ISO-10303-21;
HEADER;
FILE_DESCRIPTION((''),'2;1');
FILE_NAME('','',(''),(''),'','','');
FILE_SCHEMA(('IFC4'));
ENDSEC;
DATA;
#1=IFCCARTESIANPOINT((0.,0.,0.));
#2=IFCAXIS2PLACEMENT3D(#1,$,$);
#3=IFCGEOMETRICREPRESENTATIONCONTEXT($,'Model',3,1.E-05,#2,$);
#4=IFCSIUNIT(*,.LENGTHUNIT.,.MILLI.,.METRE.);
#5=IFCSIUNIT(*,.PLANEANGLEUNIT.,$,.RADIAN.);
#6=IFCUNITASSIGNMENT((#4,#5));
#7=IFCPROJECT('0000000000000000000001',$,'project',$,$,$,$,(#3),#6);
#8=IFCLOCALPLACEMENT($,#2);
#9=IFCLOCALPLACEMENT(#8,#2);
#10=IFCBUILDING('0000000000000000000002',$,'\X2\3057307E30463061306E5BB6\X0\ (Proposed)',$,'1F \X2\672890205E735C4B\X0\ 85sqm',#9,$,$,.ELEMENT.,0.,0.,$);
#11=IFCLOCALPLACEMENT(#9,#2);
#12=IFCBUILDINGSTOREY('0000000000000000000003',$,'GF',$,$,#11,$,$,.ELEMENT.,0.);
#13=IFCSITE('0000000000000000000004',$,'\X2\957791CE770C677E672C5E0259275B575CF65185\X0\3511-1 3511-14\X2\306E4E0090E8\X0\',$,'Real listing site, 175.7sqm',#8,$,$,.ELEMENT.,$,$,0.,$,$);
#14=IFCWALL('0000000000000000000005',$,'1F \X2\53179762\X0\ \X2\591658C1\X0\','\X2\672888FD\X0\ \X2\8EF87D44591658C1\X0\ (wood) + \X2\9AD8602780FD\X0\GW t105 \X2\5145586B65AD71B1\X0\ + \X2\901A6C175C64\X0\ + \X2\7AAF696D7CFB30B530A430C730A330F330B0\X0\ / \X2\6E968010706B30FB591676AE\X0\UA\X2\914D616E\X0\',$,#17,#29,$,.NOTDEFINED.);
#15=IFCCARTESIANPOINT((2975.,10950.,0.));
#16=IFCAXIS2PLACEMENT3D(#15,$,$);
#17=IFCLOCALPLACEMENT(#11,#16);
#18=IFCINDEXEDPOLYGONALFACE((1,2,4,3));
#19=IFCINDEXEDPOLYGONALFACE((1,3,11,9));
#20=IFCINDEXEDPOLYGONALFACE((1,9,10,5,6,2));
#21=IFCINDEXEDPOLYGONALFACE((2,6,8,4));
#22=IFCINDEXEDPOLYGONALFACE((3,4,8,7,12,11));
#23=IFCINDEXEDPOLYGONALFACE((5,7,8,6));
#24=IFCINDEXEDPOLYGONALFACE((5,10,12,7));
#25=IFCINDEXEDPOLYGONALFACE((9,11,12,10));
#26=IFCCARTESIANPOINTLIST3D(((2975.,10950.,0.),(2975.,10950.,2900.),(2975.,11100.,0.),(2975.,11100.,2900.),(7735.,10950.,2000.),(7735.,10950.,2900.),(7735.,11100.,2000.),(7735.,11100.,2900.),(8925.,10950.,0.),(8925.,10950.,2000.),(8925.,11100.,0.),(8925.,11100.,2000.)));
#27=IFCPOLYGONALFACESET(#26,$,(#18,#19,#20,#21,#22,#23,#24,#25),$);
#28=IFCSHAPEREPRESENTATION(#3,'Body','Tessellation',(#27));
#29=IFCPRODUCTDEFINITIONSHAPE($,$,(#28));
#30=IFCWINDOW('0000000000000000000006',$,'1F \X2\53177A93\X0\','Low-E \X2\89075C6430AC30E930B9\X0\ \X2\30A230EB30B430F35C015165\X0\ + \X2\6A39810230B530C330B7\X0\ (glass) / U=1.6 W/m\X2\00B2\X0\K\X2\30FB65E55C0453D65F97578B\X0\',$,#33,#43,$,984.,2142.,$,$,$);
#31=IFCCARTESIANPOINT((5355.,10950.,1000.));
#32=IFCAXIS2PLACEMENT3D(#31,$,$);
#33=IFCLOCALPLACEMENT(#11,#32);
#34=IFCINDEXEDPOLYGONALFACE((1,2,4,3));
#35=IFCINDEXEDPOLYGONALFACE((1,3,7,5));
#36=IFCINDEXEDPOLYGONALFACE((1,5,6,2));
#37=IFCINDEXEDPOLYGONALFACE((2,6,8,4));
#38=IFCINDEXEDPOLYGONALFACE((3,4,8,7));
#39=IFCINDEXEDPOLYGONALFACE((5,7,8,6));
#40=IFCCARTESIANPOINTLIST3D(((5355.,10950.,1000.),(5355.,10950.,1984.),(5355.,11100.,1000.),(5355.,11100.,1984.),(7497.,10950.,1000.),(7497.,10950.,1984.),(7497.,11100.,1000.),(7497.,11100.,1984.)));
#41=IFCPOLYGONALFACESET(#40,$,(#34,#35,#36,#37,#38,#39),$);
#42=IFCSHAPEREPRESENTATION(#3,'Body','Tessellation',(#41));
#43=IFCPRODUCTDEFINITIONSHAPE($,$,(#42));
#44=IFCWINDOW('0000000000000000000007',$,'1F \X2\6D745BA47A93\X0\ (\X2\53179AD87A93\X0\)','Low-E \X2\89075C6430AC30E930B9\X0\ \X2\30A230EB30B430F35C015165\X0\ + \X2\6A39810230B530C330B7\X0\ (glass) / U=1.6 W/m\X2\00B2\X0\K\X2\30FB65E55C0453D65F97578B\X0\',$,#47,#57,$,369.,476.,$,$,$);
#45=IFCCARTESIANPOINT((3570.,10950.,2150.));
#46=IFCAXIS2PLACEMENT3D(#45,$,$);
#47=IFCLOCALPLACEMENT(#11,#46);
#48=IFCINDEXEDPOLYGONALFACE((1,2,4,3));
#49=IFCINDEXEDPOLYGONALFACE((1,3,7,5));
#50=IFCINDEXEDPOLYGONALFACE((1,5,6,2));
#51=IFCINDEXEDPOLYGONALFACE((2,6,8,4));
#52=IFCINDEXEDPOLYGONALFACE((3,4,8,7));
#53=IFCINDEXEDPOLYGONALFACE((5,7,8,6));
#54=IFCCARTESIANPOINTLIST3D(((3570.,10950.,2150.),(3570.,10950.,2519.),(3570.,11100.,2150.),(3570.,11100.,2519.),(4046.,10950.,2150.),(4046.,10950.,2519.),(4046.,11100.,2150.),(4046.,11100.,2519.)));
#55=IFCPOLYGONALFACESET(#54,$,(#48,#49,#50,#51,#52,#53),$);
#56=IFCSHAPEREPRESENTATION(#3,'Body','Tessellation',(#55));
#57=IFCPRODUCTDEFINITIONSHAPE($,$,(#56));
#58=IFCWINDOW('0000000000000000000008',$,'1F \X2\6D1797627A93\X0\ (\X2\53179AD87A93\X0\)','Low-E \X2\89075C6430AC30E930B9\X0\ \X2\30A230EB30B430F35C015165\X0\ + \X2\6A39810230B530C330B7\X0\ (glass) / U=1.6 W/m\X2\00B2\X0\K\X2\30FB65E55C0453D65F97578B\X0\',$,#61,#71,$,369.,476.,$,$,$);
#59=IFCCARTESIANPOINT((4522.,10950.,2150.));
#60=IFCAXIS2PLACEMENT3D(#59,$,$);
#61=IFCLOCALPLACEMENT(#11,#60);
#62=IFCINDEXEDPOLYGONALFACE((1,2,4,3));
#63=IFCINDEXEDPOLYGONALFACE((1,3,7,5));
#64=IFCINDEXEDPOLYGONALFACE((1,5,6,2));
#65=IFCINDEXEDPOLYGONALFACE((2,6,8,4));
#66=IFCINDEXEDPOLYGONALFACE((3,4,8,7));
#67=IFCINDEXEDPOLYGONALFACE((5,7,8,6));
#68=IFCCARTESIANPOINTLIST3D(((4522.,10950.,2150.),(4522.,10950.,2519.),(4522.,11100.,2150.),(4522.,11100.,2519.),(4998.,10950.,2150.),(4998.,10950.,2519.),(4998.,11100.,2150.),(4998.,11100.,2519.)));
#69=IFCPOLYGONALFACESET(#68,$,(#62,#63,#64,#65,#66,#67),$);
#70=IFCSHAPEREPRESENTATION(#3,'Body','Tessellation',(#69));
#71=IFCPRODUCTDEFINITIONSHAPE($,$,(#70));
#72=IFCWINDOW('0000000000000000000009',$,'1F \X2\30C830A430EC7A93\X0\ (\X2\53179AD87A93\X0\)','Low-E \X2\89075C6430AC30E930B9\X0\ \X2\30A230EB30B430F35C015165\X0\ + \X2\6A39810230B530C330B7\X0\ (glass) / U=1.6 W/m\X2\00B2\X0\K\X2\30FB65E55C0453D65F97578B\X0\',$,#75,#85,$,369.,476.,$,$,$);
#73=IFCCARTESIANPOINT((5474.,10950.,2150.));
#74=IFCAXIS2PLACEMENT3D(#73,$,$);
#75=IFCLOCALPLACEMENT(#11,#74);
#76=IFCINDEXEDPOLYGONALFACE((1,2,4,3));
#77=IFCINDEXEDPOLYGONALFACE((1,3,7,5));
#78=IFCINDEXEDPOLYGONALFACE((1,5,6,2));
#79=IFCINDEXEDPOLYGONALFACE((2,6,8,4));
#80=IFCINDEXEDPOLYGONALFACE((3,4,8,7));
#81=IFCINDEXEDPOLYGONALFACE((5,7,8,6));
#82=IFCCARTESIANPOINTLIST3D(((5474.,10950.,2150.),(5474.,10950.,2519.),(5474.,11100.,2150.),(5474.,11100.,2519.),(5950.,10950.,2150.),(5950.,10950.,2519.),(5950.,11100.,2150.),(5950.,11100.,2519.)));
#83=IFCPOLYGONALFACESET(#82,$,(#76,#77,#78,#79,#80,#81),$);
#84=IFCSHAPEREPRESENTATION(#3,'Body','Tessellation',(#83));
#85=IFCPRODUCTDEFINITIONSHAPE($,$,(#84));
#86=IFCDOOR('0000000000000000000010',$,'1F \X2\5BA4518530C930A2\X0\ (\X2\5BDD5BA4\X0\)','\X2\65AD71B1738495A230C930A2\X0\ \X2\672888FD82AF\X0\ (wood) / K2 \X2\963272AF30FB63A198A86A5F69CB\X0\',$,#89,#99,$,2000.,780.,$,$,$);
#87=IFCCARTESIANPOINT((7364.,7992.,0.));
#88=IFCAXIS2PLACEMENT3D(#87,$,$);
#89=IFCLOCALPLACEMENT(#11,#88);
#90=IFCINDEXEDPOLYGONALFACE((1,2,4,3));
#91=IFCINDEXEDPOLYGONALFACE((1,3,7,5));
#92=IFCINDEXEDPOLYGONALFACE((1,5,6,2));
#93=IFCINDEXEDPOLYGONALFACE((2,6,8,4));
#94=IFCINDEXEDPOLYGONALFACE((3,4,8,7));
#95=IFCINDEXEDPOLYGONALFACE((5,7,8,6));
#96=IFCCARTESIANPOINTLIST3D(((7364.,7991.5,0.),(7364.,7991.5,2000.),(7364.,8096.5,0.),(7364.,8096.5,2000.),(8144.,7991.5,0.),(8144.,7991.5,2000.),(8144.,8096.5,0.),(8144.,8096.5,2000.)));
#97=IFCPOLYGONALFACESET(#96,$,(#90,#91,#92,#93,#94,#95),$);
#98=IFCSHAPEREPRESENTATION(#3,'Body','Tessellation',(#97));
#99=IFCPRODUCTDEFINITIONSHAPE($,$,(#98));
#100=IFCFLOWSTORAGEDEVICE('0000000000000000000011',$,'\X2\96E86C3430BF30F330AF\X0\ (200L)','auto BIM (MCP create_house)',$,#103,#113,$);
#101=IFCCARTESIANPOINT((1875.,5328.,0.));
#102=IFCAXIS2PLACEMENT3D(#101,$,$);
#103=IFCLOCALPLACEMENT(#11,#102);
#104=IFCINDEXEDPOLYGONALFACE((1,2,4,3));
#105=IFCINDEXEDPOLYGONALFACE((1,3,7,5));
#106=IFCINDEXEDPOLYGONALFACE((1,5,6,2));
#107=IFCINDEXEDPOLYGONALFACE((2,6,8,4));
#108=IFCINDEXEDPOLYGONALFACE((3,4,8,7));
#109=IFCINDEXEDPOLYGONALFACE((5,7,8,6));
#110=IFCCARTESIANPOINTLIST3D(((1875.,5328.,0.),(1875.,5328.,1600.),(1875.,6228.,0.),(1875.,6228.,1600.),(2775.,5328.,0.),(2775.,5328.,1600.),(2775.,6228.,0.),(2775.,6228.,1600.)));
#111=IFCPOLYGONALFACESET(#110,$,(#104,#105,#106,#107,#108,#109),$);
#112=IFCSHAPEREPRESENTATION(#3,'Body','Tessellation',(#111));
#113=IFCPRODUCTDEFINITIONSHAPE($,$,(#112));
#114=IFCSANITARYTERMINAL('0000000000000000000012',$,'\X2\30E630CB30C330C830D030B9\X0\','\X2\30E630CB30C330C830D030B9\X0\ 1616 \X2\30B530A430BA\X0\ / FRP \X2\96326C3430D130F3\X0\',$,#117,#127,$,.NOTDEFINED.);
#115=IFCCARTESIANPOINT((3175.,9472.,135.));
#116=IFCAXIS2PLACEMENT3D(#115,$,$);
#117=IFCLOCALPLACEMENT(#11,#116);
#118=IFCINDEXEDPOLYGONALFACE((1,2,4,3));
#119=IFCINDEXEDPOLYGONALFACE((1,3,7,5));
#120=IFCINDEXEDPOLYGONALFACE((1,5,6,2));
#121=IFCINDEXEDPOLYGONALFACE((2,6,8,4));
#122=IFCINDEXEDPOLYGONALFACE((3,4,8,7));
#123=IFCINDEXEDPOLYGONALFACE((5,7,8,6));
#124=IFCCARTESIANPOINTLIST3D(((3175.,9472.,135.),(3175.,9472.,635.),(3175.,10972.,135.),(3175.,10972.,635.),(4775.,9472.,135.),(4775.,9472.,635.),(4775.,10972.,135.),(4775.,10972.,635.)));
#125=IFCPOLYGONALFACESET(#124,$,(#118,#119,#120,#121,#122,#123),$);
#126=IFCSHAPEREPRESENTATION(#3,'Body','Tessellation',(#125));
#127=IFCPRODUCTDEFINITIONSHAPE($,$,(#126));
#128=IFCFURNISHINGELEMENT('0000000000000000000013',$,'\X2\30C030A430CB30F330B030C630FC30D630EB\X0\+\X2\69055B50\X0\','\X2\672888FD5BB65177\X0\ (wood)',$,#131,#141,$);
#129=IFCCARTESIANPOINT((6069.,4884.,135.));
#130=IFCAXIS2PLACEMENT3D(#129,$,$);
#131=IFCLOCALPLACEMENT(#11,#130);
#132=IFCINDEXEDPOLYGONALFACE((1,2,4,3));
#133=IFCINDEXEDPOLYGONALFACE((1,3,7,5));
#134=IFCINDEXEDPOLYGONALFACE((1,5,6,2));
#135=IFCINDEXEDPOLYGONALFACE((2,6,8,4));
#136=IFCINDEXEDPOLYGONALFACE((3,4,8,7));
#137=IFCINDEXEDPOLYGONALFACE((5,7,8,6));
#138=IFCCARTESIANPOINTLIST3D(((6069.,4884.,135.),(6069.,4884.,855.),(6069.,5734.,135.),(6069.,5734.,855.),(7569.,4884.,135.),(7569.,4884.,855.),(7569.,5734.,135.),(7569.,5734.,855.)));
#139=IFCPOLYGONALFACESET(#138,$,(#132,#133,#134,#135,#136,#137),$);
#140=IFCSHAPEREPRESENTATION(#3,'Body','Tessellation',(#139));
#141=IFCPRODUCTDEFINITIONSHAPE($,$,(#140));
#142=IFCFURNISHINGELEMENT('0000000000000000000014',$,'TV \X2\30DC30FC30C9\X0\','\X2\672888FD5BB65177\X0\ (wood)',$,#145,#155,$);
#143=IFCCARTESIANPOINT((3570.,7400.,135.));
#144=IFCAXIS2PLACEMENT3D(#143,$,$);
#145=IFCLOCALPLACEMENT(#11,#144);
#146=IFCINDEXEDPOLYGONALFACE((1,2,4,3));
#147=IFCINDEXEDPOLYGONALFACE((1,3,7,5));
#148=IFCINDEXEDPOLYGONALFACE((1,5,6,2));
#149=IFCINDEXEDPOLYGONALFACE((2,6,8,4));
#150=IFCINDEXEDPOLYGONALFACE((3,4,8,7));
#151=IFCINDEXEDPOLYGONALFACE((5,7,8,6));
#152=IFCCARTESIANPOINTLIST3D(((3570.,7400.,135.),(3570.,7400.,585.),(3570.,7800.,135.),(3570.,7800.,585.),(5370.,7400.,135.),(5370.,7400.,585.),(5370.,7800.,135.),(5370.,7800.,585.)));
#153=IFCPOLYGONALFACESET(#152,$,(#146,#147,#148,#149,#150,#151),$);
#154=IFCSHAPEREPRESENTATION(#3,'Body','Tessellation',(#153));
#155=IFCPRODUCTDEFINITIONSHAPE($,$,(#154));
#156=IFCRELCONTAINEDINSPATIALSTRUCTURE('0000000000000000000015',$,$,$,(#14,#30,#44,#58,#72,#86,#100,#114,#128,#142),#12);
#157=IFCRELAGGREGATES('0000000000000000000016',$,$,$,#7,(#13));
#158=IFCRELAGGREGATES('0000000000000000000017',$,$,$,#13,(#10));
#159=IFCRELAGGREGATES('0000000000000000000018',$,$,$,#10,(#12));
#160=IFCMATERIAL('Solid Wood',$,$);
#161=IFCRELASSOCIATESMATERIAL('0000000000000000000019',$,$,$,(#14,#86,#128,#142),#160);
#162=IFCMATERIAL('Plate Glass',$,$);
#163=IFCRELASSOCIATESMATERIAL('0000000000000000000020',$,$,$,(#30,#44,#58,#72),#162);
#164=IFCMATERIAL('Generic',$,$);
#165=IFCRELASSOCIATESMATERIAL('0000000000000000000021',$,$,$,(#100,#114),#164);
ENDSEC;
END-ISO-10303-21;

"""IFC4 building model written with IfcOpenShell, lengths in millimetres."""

from ifc_helpers import new_model, si_unit, frame, frame_2d, origin, place, context, project, spatial, rectangle, extrude, material, element, fill, save


model = new_model("IFC4")

# Units and contexts
model_context = context("Model", 3, precision=1e-05, world=origin())
ifc_project = project(units=[si_unit("LENGTHUNIT", "METRE", prefix="MILLI"), si_unit("PLANEANGLEUNIT", "RADIAN")], contexts=[model_context])

# Site, building, storey
site_placement = place(None, origin())
site = spatial("IfcSite", under=ifc_project, at=site_placement, Name="長野県松本市大字島内3511-1 3511-14の一部", ObjectType="Real listing site, 175.7sqm", CompositionType="ELEMENT", RefElevation=0.0)
building_placement = place(site_placement, origin())
building = spatial("IfcBuilding", under=site, at=building_placement, Name="しまうちの家 (Proposed)", ObjectType="1F 木造平屋 85sqm", CompositionType="ELEMENT", ElevationOfRefHeight=0.0, ElevationOfTerrain=0.0)
storey_placement = place(building_placement, origin())
storey = spatial("IfcBuildingStorey", under=building, at=storey_placement, Name="GF", CompositionType="ELEMENT", Elevation=0.0)

# Wall, openings, windows
ifc_material_1 = material(Name="Solid Wood")
wall_1_placement = place(storey_placement, frame((2975.0, 10950.0, 0.0)))
wall_1 = element("IfcWall", 1, at=wall_1_placement, inside=storey, material=ifc_material_1, Name="1F 北面 外壁", Description="木製 軸組外壁 (wood) + 高性能GW t105 充填断熱 + 通気層 + 窯業系サイディング / 準耐火・外皮UA配慮", PredefinedType="NOTDEFINED", context=model_context, shape_type="SweptSolid", body=[
    extrude(rectangle(XDim=5950.0, YDim=150.0, at=frame_2d((2975.0, 75.0))), frame((2975.0, 10950.0, 0.0)), (0.0, 0.0, 1.0), 2900.0),
])
opening_1_placement = place(storey_placement, frame((5355.0, 10950.0, 1000.0)))
opening_1 = element("IfcOpeningElement", 2, at=opening_1_placement, cuts=wall_1, PredefinedType="NOTDEFINED", context=model_context, shape_type="SweptSolid", body=[
    extrude(rectangle(XDim=2142.0, YDim=150.0, at=frame_2d((1071.0, 75.0))), frame((5355.0, 10950.0, 1000.0)), (0.0, 0.0, 1.0), 984.0),
])
opening_2_placement = place(storey_placement, frame((3570.0, 10950.0, 2150.0)))
opening_2 = element("IfcOpeningElement", 3, at=opening_2_placement, cuts=wall_1, PredefinedType="NOTDEFINED", context=model_context, shape_type="SweptSolid", body=[
    extrude(rectangle(XDim=476.0, YDim=150.0, at=frame_2d((238.0, 75.0))), frame((3570.0, 10950.0, 2150.0)), (0.0, 0.0, 1.0), 369.0),
])
opening_3_placement = place(storey_placement, frame((4522.0, 10950.0, 2150.0)))
opening_3 = element("IfcOpeningElement", 4, at=opening_3_placement, cuts=wall_1, PredefinedType="NOTDEFINED", context=model_context, shape_type="SweptSolid", body=[
    extrude(rectangle(XDim=476.0, YDim=150.0, at=frame_2d((238.0, 75.0))), frame((4522.0, 10950.0, 2150.0)), (0.0, 0.0, 1.0), 369.0),
])
opening_4_placement = place(storey_placement, frame((5474.0, 10950.0, 2150.0)))
opening_4 = element("IfcOpeningElement", 5, at=opening_4_placement, cuts=wall_1, PredefinedType="NOTDEFINED", context=model_context, shape_type="SweptSolid", body=[
    extrude(rectangle(XDim=476.0, YDim=150.0, at=frame_2d((238.0, 75.0))), frame((5474.0, 10950.0, 2150.0)), (0.0, 0.0, 1.0), 369.0),
])
ifc_material_2 = material(Name="Plate Glass")
window_1_placement = place(storey_placement, frame((5355.0, 10950.0, 1000.0)))
window_1 = element("IfcWindow", 6, at=window_1_placement, inside=storey, material=ifc_material_2, Name="1F 北窓", Description="Low-E 複層ガラス アルゴン封入 + 樹脂サッシ (glass) / U=1.6 W/m²K・日射取得型", OverallHeight=984.0, OverallWidth=2142.0, context=model_context, shape_type="SweptSolid", body=[
    extrude(rectangle(XDim=2142.0, YDim=150.0, at=frame_2d((1071.0, 75.0))), frame((5355.0, 10950.0, 1000.0)), (0.0, 0.0, 1.0), 984.0),
])
fill(opening_1, window_1)
window_2_placement = place(storey_placement, frame((3570.0, 10950.0, 2150.0)))
window_2 = element("IfcWindow", 7, at=window_2_placement, inside=storey, material=ifc_material_2, Name="1F 浴室窓 (北高窓)", Description="Low-E 複層ガラス アルゴン封入 + 樹脂サッシ (glass) / U=1.6 W/m²K・日射取得型", OverallHeight=369.0, OverallWidth=476.0, context=model_context, shape_type="SweptSolid", body=[
    extrude(rectangle(XDim=476.0, YDim=150.0, at=frame_2d((238.0, 75.0))), frame((3570.0, 10950.0, 2150.0)), (0.0, 0.0, 1.0), 369.0),
])
fill(opening_2, window_2)
window_3_placement = place(storey_placement, frame((4522.0, 10950.0, 2150.0)))
window_3 = element("IfcWindow", 8, at=window_3_placement, inside=storey, material=ifc_material_2, Name="1F 洗面窓 (北高窓)", Description="Low-E 複層ガラス アルゴン封入 + 樹脂サッシ (glass) / U=1.6 W/m²K・日射取得型", OverallHeight=369.0, OverallWidth=476.0, context=model_context, shape_type="SweptSolid", body=[
    extrude(rectangle(XDim=476.0, YDim=150.0, at=frame_2d((238.0, 75.0))), frame((4522.0, 10950.0, 2150.0)), (0.0, 0.0, 1.0), 369.0),
])
fill(opening_3, window_3)
window_4_placement = place(storey_placement, frame((5474.0, 10950.0, 2150.0)))
window_4 = element("IfcWindow", 9, at=window_4_placement, inside=storey, material=ifc_material_2, Name="1F トイレ窓 (北高窓)", Description="Low-E 複層ガラス アルゴン封入 + 樹脂サッシ (glass) / U=1.6 W/m²K・日射取得型", OverallHeight=369.0, OverallWidth=476.0, context=model_context, shape_type="SweptSolid", body=[
    extrude(rectangle(XDim=476.0, YDim=150.0, at=frame_2d((238.0, 75.0))), frame((5474.0, 10950.0, 2150.0)), (0.0, 0.0, 1.0), 369.0),
])
fill(opening_4, window_4)

# Door
door_1_placement = place(storey_placement, frame((7364.0, 7992.0, 0.0)))
element("IfcDoor", 10, at=door_1_placement, inside=storey, material=ifc_material_1, Name="1F 室内ドア (寝室)", Description="断熱玄関ドア 木製芯 (wood) / K2 防犯・採風機構", OverallHeight=2000.0, OverallWidth=780.0, context=model_context, shape_type="SweptSolid", body=[
    extrude(rectangle(XDim=780.0, YDim=105.0, at=frame_2d((390.0, 52.0))), frame((7364.0, 7992.0, 0.0)), (0.0, 0.0, 1.0), 2000.0),
])

# Flow storage device
ifc_material_3 = material(Name="Generic")
flow_storage_device_placement = place(storey_placement, frame((1875.0, 5328.0, 0.0)))
element("IfcFlowStorageDevice", 11, at=flow_storage_device_placement, inside=storey, material=ifc_material_3, Name="雨水タンク (200L)", Description="auto BIM (MCP create_house)", context=model_context, shape_type="SweptSolid", body=[
    extrude(rectangle(XDim=900.0, YDim=900.0, at=frame_2d((450.0, 450.0))), frame((1875.0, 5328.0, 0.0)), (0.0, 0.0, 1.0), 1600.0),
])

# Sanitary terminal
sanitary_terminal_placement = place(storey_placement, frame((3175.0, 9472.0, 135.0)))
element("IfcSanitaryTerminal", 12, at=sanitary_terminal_placement, inside=storey, material=ifc_material_3, Name="ユニットバス", Description="ユニットバス 1616 サイズ / FRP 防水パン", PredefinedType="NOTDEFINED", context=model_context, shape_type="SweptSolid", body=[
    extrude(rectangle(XDim=1600.0, YDim=1500.0, at=frame_2d((800.0, 750.0))), frame((3175.0, 9472.0, 135.0)), (0.0, 0.0, 1.0), 500.0),
])

# Furnishing elements
furnishing_1_placement = place(storey_placement, frame((6069.0, 4884.0, 135.0)))
element("IfcFurnishingElement", 13, at=furnishing_1_placement, inside=storey, material=ifc_material_1, Name="ダイニングテーブル+椅子", Description="木製家具 (wood)", context=model_context, shape_type="SweptSolid", body=[
    extrude(rectangle(XDim=1500.0, YDim=850.0, at=frame_2d((750.0, 425.0))), frame((6069.0, 4884.0, 135.0)), (0.0, 0.0, 1.0), 720.0),
])
furnishing_2_placement = place(storey_placement, frame((3570.0, 7400.0, 135.0)))
element("IfcFurnishingElement", 14, at=furnishing_2_placement, inside=storey, material=ifc_material_1, Name="TV ボード", Description="木製家具 (wood)", context=model_context, shape_type="SweptSolid", body=[
    extrude(rectangle(XDim=1800.0, YDim=400.0, at=frame_2d((900.0, 200.0))), frame((3570.0, 7400.0, 135.0)), (0.0, 0.0, 1.0), 450.0),
])

save(model, "model.ifc")
